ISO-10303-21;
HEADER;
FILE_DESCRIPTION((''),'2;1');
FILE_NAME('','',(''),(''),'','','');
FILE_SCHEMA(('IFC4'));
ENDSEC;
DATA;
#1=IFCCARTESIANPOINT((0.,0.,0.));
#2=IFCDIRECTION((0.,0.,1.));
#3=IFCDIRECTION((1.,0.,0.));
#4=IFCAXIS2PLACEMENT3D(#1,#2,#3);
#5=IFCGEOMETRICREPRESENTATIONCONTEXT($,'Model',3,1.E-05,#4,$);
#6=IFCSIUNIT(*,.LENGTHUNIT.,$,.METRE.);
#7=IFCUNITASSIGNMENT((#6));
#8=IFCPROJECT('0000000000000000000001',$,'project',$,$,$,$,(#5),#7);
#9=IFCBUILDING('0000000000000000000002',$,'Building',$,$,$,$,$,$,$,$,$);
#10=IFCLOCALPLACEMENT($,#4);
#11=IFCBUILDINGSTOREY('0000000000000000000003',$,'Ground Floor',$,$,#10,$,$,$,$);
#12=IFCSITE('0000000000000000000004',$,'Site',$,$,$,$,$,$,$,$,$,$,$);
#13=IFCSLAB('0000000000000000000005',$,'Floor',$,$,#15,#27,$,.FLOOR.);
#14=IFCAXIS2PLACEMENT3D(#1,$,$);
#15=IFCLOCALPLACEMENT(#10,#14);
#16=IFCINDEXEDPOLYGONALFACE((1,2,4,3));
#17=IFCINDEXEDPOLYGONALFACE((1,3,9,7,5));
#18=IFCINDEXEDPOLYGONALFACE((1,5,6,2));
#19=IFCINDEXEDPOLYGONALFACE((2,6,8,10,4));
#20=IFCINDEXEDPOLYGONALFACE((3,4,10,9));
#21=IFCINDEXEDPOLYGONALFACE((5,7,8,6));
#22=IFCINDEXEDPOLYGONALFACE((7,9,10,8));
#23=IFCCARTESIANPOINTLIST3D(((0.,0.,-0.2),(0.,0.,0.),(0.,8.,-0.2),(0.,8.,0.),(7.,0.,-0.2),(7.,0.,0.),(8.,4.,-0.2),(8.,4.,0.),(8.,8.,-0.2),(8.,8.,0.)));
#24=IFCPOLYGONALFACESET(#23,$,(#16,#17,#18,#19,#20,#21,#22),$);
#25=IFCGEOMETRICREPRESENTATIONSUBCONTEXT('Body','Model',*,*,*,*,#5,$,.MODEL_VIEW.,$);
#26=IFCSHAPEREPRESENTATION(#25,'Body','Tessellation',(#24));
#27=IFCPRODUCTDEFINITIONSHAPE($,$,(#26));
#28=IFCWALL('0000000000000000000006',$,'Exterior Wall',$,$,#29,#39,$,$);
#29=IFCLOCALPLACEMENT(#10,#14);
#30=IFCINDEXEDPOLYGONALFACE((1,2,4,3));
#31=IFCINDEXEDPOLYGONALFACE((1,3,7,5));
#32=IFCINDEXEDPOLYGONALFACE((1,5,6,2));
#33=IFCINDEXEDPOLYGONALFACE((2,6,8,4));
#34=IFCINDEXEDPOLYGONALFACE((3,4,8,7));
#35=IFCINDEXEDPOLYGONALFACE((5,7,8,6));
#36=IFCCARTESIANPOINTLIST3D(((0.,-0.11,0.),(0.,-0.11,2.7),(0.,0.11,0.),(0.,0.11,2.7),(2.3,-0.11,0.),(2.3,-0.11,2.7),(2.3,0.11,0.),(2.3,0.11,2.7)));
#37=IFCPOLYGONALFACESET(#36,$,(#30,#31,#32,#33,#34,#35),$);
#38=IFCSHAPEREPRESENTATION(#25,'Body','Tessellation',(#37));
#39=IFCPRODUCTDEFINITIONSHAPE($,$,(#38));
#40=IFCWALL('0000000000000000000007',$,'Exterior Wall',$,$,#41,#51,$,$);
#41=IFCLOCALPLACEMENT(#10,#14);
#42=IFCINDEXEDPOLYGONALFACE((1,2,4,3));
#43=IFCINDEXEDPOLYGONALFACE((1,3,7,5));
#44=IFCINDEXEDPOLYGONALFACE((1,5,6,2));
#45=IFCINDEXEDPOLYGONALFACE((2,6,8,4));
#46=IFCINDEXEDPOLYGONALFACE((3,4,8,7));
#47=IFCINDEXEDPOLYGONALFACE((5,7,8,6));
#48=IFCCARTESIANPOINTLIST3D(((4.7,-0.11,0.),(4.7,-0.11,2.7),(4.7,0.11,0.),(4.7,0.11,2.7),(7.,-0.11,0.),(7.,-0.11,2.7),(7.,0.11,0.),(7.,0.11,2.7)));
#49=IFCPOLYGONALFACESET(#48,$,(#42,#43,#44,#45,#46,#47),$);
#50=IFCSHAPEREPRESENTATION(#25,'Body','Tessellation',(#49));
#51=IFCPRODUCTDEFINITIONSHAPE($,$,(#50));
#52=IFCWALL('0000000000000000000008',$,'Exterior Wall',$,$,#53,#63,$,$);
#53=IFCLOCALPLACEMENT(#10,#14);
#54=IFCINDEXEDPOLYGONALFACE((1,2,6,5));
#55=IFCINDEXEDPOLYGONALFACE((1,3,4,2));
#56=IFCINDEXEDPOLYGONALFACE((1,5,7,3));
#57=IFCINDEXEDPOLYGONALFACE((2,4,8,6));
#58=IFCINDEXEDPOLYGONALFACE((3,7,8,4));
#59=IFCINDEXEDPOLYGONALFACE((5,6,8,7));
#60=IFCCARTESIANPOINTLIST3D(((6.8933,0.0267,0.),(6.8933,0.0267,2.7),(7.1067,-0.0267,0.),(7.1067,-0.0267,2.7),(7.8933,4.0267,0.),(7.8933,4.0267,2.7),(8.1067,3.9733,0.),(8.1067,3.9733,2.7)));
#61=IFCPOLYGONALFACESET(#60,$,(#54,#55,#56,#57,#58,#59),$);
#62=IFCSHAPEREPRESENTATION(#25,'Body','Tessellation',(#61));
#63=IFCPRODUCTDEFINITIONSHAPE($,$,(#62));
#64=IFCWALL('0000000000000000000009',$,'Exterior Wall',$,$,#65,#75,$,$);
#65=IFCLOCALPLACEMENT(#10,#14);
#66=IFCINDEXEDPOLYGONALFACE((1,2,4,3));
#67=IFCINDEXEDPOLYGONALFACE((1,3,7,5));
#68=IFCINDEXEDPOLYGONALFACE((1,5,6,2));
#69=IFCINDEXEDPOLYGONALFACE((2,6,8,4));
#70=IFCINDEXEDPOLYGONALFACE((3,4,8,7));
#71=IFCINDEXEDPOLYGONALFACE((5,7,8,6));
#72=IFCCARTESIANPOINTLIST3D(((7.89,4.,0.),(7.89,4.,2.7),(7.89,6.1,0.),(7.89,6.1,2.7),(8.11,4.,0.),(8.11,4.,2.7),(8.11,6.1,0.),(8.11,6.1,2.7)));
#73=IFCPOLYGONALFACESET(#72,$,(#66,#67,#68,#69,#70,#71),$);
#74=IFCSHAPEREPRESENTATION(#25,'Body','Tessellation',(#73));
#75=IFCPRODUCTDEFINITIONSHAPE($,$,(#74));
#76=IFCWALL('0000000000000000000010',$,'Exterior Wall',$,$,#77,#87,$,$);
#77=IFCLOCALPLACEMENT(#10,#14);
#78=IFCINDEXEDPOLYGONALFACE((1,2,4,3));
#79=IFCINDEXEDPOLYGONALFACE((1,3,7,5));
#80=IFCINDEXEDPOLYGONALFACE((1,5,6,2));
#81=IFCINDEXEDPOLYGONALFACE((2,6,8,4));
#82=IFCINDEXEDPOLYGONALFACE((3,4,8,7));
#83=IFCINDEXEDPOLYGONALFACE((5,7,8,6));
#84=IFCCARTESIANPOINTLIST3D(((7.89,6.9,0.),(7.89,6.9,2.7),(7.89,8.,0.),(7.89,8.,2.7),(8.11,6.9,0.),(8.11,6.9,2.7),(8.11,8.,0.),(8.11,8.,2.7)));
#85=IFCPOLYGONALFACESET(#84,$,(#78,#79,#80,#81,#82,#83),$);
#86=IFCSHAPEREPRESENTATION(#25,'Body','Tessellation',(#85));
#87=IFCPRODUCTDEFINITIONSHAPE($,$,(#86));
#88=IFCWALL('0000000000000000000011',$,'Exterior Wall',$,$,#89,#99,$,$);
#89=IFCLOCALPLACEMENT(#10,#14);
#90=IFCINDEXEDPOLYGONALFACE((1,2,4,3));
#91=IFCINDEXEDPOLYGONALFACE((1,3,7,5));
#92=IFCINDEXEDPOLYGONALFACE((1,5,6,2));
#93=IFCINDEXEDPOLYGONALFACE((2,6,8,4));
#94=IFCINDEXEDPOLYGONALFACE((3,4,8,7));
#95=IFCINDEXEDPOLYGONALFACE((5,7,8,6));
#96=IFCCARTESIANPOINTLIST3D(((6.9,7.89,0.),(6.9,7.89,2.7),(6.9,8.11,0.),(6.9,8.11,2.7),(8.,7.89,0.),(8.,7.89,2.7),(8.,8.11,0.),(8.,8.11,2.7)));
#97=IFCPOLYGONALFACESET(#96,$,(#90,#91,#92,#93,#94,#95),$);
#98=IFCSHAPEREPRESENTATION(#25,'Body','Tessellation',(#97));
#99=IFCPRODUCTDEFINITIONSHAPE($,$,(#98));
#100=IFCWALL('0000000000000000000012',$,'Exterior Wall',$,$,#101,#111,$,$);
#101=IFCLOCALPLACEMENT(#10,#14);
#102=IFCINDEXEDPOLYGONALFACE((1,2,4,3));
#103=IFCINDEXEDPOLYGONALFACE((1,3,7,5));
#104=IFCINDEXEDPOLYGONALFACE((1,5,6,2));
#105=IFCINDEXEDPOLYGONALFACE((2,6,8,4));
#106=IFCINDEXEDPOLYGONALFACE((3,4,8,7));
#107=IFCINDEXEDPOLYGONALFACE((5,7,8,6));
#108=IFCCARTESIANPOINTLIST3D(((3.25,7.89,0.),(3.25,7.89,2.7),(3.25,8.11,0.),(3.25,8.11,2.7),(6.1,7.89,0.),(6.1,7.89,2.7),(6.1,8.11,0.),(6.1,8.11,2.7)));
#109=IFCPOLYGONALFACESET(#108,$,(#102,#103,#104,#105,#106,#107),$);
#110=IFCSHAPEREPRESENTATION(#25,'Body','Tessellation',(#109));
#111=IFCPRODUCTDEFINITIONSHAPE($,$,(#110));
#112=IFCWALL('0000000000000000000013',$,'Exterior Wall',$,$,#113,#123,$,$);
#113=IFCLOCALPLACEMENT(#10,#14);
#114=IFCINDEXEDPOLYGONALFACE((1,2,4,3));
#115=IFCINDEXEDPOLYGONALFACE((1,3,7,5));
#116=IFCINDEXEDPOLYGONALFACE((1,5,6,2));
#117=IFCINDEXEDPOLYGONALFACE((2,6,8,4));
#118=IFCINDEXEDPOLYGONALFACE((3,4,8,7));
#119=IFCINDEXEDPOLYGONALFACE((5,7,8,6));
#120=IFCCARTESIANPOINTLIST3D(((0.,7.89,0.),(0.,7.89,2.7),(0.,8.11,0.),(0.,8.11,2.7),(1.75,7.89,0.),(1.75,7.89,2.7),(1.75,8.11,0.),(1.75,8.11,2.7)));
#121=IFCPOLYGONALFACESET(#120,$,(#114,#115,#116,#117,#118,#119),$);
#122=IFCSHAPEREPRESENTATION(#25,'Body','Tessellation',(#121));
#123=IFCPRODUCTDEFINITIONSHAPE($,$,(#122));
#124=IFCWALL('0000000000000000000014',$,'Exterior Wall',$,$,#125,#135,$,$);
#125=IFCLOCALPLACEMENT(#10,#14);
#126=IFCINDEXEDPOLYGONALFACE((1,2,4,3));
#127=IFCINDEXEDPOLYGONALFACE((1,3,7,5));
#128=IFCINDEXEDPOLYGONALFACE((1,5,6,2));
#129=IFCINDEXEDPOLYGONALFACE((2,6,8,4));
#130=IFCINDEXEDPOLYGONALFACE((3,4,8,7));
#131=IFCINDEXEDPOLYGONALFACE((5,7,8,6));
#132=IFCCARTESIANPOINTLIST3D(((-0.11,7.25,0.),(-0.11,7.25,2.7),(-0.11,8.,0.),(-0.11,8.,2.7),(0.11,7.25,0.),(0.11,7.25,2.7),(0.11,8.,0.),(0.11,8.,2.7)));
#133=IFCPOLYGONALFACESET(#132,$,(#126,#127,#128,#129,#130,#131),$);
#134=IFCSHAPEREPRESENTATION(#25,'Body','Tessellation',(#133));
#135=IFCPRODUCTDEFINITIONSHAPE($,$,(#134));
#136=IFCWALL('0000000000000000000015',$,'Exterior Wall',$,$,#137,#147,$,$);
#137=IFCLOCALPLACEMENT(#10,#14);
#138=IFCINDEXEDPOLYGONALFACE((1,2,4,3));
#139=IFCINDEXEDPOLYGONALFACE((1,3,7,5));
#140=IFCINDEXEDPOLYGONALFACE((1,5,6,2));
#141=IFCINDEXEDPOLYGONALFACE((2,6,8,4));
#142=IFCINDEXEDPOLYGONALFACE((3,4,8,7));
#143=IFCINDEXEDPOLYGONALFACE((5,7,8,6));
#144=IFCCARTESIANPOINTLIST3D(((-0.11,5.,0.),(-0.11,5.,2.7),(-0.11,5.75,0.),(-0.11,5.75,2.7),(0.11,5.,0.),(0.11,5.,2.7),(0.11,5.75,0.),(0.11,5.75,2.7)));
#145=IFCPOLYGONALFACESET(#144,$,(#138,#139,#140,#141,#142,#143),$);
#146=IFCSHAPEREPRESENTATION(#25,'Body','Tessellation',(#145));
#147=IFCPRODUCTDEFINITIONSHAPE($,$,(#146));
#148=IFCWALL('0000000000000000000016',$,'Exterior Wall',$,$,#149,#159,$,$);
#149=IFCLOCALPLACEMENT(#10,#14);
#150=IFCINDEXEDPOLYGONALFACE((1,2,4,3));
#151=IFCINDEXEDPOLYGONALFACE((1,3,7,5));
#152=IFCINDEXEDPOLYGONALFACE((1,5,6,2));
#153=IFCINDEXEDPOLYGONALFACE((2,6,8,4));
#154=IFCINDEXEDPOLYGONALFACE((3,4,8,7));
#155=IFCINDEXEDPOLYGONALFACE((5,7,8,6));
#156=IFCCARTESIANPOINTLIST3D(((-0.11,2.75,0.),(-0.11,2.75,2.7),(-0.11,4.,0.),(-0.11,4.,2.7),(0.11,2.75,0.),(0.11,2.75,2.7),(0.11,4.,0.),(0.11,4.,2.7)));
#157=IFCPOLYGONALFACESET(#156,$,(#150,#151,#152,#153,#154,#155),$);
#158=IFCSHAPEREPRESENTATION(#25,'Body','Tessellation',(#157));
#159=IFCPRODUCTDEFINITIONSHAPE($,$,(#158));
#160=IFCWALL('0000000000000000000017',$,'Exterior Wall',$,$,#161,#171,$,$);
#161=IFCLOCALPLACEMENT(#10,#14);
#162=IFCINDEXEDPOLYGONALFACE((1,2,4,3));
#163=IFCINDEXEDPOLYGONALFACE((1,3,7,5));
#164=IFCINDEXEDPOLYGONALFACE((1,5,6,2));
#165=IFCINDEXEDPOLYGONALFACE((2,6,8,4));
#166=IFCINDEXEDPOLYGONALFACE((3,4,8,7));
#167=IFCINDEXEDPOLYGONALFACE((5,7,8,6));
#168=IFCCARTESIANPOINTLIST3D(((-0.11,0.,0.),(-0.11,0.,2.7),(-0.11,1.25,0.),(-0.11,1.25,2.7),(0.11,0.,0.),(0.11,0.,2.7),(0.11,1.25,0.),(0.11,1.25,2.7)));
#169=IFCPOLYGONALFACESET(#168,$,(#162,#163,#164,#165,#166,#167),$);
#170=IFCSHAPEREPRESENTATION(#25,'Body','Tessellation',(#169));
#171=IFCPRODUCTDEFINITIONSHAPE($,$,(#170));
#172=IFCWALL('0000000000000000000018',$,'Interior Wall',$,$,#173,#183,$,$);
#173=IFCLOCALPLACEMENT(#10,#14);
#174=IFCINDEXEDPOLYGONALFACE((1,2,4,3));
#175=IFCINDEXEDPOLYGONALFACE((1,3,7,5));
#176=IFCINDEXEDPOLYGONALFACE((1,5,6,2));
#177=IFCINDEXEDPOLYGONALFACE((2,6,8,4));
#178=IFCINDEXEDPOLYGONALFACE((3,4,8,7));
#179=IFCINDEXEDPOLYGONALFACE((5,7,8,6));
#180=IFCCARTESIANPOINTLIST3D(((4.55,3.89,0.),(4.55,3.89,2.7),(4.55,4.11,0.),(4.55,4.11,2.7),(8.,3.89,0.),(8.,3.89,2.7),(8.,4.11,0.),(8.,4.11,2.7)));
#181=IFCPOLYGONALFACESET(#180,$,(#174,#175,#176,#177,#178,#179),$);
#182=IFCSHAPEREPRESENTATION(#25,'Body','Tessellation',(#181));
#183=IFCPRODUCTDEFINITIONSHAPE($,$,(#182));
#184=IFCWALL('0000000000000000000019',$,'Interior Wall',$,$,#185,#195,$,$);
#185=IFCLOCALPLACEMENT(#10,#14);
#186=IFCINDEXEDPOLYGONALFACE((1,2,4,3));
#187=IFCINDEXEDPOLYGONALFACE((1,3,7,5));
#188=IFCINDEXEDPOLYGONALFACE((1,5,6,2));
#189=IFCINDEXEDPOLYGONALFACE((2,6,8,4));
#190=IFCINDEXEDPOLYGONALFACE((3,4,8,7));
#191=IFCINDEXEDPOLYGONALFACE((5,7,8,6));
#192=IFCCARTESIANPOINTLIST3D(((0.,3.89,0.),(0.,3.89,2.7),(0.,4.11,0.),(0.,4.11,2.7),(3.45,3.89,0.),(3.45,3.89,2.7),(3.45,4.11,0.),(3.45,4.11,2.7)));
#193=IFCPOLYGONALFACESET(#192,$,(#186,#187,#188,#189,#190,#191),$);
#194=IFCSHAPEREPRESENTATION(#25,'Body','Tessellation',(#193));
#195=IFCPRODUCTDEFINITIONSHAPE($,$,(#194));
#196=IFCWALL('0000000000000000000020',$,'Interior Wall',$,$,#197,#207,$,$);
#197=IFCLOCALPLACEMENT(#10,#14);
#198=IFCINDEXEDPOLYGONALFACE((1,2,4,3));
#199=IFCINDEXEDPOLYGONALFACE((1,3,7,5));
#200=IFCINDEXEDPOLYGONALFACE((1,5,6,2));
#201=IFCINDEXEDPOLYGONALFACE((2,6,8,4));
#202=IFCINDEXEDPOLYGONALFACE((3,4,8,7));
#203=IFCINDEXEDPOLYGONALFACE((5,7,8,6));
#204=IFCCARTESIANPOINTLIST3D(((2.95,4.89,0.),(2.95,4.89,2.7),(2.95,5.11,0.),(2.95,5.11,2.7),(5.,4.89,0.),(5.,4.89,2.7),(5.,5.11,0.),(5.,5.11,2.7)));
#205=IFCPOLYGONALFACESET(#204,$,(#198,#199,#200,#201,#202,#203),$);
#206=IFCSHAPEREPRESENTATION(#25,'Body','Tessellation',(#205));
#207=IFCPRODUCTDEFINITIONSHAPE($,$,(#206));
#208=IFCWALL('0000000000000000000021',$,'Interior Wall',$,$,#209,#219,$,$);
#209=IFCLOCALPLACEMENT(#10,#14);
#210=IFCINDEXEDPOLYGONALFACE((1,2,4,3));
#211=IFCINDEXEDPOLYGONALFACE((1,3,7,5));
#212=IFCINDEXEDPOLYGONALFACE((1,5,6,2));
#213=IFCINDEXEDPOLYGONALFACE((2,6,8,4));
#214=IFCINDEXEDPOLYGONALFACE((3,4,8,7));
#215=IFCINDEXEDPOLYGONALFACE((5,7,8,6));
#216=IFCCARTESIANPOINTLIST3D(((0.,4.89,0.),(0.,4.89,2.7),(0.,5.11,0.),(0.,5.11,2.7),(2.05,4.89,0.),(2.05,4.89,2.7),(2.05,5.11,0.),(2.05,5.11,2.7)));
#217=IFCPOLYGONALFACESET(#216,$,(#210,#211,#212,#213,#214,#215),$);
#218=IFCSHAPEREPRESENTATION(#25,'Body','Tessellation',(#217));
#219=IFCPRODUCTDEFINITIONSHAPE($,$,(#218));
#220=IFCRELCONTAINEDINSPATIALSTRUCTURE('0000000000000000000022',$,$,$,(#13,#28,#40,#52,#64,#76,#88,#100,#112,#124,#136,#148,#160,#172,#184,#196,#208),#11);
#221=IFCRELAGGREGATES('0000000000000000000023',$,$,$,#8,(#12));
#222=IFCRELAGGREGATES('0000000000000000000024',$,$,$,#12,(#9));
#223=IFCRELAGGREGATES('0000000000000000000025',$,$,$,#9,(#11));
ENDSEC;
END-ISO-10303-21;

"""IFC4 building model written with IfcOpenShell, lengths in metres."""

from ifc_helpers import new_model, si_unit, frame, origin_with_axes, place, context, subcontext, project, spatial, indexed_curve, outline, extrude, element, save


model = new_model("IFC4")

# Units and contexts
model_context = context("Model", 3, precision=1e-05, world=origin_with_axes())
body_context = subcontext(model_context, "Body", "Model", "MODEL_VIEW")
ifc_project = project(units=[si_unit("LENGTHUNIT", "METRE")], contexts=[model_context])

# Site, building, storey
site = spatial("IfcSite", under=ifc_project, Name="Site")
building = spatial("IfcBuilding", under=site, Name="Building")
storey_placement = place(None, origin_with_axes())
storey = spatial("IfcBuildingStorey", under=building, at=storey_placement, Name="Ground Floor")

# Slab
slab_placement = place(storey_placement, frame((0.0, 0.0, -0.2), z_axis=(0.0, 0.0, 1.0), x_axis=(1.0, 0.0, 0.0)))
element("IfcSlab", 1, at=slab_placement, inside=storey, Name="Floor", PredefinedType="FLOOR", context=body_context, shape_type="SweptSolid", body=[
    extrude(outline(indexed_curve([(0.0, 0.0), (7.0, 0.0), (8.0, 4.0), (8.0, 8.0), (0.0, 8.0)])), None, (0.0, 0.0, 1.0), 0.2),
])

# Walls
for number, where, z_axis, x_axis, name in (
    (2, (0.0, 0.0, 0.0), (0.0, 0.0, 1.0), (1.0, 0.0, 0.0), "Exterior Wall"),
    (3, (4.7, 0.0, 0.0), (0.0, 0.0, 1.0), (1.0, 0.0, 0.0), "Exterior Wall"),
):
    element("IfcWall", number, at=place(storey_placement, frame(where, z_axis=z_axis, x_axis=x_axis)), inside=storey, Name=name, context=body_context, shape_type="SweptSolid", body=[
        extrude(outline(indexed_curve([(0.0, 0.0), (0.0, 0.22), (2.3, 0.22), (2.3, 0.0), (0.0, 0.0)], self_intersect=False)), frame((0.0, -0.11, 0.0), z_axis=(0.0, 0.0, 1.0), x_axis=(1.0, 0.0, 0.0)), (0.0, 0.0, 1.0), 2.7),
    ])
wall_1_placement = place(storey_placement, frame((7.0, 0.0, 0.0), z_axis=(0.0, 0.0, 1.0), x_axis=(0.242536, 0.970143, 0.0)))
element("IfcWall", 4, at=wall_1_placement, inside=storey, Name="Exterior Wall", context=body_context, shape_type="SweptSolid", body=[
    extrude(outline(indexed_curve([(0.0, 0.0), (0.0, 0.22), (4.1231, 0.22), (4.1231, 0.0), (0.0, 0.0)], self_intersect=False)), frame((0.0, -0.11, 0.0), z_axis=(0.0, 0.0, 1.0), x_axis=(1.0, 0.0, 0.0)), (0.0, 0.0, 1.0), 2.7),
])
wall_2_placement = place(storey_placement, frame((8.0, 4.0, 0.0), z_axis=(0.0, 0.0, 1.0), x_axis=(0.0, 1.0, 0.0)))
element("IfcWall", 5, at=wall_2_placement, inside=storey, Name="Exterior Wall", context=body_context, shape_type="SweptSolid", body=[
    extrude(outline(indexed_curve([(0.0, 0.0), (0.0, 0.22), (2.1, 0.22), (2.1, 0.0), (0.0, 0.0)], self_intersect=False)), frame((0.0, -0.11, 0.0), z_axis=(0.0, 0.0, 1.0), x_axis=(1.0, 0.0, 0.0)), (0.0, 0.0, 1.0), 2.7),
])
for number, where, z_axis, x_axis, name in (
    (6, (8.0, 6.9, 0.0), (0.0, 0.0, 1.0), (0.0, 1.0, 0.0), "Exterior Wall"),
    (7, (8.0, 8.0, 0.0), (0.0, 0.0, 1.0), (-1.0, 0.0, 0.0), "Exterior Wall"),
):
    element("IfcWall", number, at=place(storey_placement, frame(where, z_axis=z_axis, x_axis=x_axis)), inside=storey, Name=name, context=body_context, shape_type="SweptSolid", body=[
        extrude(outline(indexed_curve([(0.0, 0.0), (0.0, 0.22), (1.1, 0.22), (1.1, 0.0), (0.0, 0.0)], self_intersect=False)), frame((0.0, -0.11, 0.0), z_axis=(0.0, 0.0, 1.0), x_axis=(1.0, 0.0, 0.0)), (0.0, 0.0, 1.0), 2.7),
    ])
wall_3_placement = place(storey_placement, frame((6.1, 8.0, 0.0), z_axis=(0.0, 0.0, 1.0), x_axis=(-1.0, 0.0, 0.0)))
element("IfcWall", 8, at=wall_3_placement, inside=storey, Name="Exterior Wall", context=body_context, shape_type="SweptSolid", body=[
    extrude(outline(indexed_curve([(0.0, 0.0), (0.0, 0.22), (2.85, 0.22), (2.85, 0.0), (0.0, 0.0)], self_intersect=False)), frame((0.0, -0.11, 0.0), z_axis=(0.0, 0.0, 1.0), x_axis=(1.0, 0.0, 0.0)), (0.0, 0.0, 1.0), 2.7),
])
wall_4_placement = place(storey_placement, frame((1.75, 8.0, 0.0), z_axis=(0.0, 0.0, 1.0), x_axis=(-1.0, 0.0, 0.0)))
element("IfcWall", 9, at=wall_4_placement, inside=storey, Name="Exterior Wall", context=body_context, shape_type="SweptSolid", body=[
    extrude(outline(indexed_curve([(0.0, 0.0), (0.0, 0.22), (1.75, 0.22), (1.75, 0.0), (0.0, 0.0)], self_intersect=False)), frame((0.0, -0.11, 0.0), z_axis=(0.0, 0.0, 1.0), x_axis=(1.0, 0.0, 0.0)), (0.0, 0.0, 1.0), 2.7),
])
for number, where, z_axis, x_axis, name in (
    (10, (0.0, 8.0, 0.0), (0.0, 0.0, 1.0), (0.0, -1.0, 0.0), "Exterior Wall"),
    (11, (0.0, 5.75, 0.0), (0.0, 0.0, 1.0), (0.0, -1.0, 0.0), "Exterior Wall"),
):
    element("IfcWall", number, at=place(storey_placement, frame(where, z_axis=z_axis, x_axis=x_axis)), inside=storey, Name=name, context=body_context, shape_type="SweptSolid", body=[
        extrude(outline(indexed_curve([(0.0, 0.0), (0.0, 0.22), (0.75, 0.22), (0.75, 0.0), (0.0, 0.0)], self_intersect=False)), frame((0.0, -0.11, 0.0), z_axis=(0.0, 0.0, 1.0), x_axis=(1.0, 0.0, 0.0)), (0.0, 0.0, 1.0), 2.7),
    ])
for number, where, z_axis, x_axis, name in (
    (12, (0.0, 4.0, 0.0), (0.0, 0.0, 1.0), (0.0, -1.0, 0.0), "Exterior Wall"),
    (13, (0.0, 1.25, 0.0), (0.0, 0.0, 1.0), (0.0, -1.0, 0.0), "Exterior Wall"),
):
    element("IfcWall", number, at=place(storey_placement, frame(where, z_axis=z_axis, x_axis=x_axis)), inside=storey, Name=name, context=body_context, shape_type="SweptSolid", body=[
        extrude(outline(indexed_curve([(0.0, 0.0), (0.0, 0.22), (1.25, 0.22), (1.25, 0.0), (0.0, 0.0)], self_intersect=False)), frame((0.0, -0.11, 0.0), z_axis=(0.0, 0.0, 1.0), x_axis=(1.0, 0.0, 0.0)), (0.0, 0.0, 1.0), 2.7),
    ])
for number, where, z_axis, x_axis, name in (
    (14, (8.0, 4.0, 0.0), (0.0, 0.0, 1.0), (-1.0, 0.0, 0.0), "Interior Wall"),
    (15, (3.45, 4.0, 0.0), (0.0, 0.0, 1.0), (-1.0, 0.0, 0.0), "Interior Wall"),
):
    element("IfcWall", number, at=place(storey_placement, frame(where, z_axis=z_axis, x_axis=x_axis)), inside=storey, Name=name, context=body_context, shape_type="SweptSolid", body=[
        extrude(outline(indexed_curve([(0.0, 0.0), (0.0, 0.22), (3.45, 0.22), (3.45, 0.0), (0.0, 0.0)], self_intersect=False)), frame((0.0, -0.11, 0.0), z_axis=(0.0, 0.0, 1.0), x_axis=(1.0, 0.0, 0.0)), (0.0, 0.0, 1.0), 2.7),
    ])
for number, where, z_axis, x_axis, name in (
    (16, (5.0, 5.0, 0.0), (0.0, 0.0, 1.0), (-1.0, 0.0, 0.0), "Interior Wall"),
    (17, (2.05, 5.0, 0.0), (0.0, 0.0, 1.0), (-1.0, 0.0, 0.0), "Interior Wall"),
):
    element("IfcWall", number, at=place(storey_placement, frame(where, z_axis=z_axis, x_axis=x_axis)), inside=storey, Name=name, context=body_context, shape_type="SweptSolid", body=[
        extrude(outline(indexed_curve([(0.0, 0.0), (0.0, 0.22), (2.05, 0.22), (2.05, 0.0), (0.0, 0.0)], self_intersect=False)), frame((0.0, -0.11, 0.0), z_axis=(0.0, 0.0, 1.0), x_axis=(1.0, 0.0, 0.0)), (0.0, 0.0, 1.0), 2.7),
    ])

save(model, "model.ifc")
